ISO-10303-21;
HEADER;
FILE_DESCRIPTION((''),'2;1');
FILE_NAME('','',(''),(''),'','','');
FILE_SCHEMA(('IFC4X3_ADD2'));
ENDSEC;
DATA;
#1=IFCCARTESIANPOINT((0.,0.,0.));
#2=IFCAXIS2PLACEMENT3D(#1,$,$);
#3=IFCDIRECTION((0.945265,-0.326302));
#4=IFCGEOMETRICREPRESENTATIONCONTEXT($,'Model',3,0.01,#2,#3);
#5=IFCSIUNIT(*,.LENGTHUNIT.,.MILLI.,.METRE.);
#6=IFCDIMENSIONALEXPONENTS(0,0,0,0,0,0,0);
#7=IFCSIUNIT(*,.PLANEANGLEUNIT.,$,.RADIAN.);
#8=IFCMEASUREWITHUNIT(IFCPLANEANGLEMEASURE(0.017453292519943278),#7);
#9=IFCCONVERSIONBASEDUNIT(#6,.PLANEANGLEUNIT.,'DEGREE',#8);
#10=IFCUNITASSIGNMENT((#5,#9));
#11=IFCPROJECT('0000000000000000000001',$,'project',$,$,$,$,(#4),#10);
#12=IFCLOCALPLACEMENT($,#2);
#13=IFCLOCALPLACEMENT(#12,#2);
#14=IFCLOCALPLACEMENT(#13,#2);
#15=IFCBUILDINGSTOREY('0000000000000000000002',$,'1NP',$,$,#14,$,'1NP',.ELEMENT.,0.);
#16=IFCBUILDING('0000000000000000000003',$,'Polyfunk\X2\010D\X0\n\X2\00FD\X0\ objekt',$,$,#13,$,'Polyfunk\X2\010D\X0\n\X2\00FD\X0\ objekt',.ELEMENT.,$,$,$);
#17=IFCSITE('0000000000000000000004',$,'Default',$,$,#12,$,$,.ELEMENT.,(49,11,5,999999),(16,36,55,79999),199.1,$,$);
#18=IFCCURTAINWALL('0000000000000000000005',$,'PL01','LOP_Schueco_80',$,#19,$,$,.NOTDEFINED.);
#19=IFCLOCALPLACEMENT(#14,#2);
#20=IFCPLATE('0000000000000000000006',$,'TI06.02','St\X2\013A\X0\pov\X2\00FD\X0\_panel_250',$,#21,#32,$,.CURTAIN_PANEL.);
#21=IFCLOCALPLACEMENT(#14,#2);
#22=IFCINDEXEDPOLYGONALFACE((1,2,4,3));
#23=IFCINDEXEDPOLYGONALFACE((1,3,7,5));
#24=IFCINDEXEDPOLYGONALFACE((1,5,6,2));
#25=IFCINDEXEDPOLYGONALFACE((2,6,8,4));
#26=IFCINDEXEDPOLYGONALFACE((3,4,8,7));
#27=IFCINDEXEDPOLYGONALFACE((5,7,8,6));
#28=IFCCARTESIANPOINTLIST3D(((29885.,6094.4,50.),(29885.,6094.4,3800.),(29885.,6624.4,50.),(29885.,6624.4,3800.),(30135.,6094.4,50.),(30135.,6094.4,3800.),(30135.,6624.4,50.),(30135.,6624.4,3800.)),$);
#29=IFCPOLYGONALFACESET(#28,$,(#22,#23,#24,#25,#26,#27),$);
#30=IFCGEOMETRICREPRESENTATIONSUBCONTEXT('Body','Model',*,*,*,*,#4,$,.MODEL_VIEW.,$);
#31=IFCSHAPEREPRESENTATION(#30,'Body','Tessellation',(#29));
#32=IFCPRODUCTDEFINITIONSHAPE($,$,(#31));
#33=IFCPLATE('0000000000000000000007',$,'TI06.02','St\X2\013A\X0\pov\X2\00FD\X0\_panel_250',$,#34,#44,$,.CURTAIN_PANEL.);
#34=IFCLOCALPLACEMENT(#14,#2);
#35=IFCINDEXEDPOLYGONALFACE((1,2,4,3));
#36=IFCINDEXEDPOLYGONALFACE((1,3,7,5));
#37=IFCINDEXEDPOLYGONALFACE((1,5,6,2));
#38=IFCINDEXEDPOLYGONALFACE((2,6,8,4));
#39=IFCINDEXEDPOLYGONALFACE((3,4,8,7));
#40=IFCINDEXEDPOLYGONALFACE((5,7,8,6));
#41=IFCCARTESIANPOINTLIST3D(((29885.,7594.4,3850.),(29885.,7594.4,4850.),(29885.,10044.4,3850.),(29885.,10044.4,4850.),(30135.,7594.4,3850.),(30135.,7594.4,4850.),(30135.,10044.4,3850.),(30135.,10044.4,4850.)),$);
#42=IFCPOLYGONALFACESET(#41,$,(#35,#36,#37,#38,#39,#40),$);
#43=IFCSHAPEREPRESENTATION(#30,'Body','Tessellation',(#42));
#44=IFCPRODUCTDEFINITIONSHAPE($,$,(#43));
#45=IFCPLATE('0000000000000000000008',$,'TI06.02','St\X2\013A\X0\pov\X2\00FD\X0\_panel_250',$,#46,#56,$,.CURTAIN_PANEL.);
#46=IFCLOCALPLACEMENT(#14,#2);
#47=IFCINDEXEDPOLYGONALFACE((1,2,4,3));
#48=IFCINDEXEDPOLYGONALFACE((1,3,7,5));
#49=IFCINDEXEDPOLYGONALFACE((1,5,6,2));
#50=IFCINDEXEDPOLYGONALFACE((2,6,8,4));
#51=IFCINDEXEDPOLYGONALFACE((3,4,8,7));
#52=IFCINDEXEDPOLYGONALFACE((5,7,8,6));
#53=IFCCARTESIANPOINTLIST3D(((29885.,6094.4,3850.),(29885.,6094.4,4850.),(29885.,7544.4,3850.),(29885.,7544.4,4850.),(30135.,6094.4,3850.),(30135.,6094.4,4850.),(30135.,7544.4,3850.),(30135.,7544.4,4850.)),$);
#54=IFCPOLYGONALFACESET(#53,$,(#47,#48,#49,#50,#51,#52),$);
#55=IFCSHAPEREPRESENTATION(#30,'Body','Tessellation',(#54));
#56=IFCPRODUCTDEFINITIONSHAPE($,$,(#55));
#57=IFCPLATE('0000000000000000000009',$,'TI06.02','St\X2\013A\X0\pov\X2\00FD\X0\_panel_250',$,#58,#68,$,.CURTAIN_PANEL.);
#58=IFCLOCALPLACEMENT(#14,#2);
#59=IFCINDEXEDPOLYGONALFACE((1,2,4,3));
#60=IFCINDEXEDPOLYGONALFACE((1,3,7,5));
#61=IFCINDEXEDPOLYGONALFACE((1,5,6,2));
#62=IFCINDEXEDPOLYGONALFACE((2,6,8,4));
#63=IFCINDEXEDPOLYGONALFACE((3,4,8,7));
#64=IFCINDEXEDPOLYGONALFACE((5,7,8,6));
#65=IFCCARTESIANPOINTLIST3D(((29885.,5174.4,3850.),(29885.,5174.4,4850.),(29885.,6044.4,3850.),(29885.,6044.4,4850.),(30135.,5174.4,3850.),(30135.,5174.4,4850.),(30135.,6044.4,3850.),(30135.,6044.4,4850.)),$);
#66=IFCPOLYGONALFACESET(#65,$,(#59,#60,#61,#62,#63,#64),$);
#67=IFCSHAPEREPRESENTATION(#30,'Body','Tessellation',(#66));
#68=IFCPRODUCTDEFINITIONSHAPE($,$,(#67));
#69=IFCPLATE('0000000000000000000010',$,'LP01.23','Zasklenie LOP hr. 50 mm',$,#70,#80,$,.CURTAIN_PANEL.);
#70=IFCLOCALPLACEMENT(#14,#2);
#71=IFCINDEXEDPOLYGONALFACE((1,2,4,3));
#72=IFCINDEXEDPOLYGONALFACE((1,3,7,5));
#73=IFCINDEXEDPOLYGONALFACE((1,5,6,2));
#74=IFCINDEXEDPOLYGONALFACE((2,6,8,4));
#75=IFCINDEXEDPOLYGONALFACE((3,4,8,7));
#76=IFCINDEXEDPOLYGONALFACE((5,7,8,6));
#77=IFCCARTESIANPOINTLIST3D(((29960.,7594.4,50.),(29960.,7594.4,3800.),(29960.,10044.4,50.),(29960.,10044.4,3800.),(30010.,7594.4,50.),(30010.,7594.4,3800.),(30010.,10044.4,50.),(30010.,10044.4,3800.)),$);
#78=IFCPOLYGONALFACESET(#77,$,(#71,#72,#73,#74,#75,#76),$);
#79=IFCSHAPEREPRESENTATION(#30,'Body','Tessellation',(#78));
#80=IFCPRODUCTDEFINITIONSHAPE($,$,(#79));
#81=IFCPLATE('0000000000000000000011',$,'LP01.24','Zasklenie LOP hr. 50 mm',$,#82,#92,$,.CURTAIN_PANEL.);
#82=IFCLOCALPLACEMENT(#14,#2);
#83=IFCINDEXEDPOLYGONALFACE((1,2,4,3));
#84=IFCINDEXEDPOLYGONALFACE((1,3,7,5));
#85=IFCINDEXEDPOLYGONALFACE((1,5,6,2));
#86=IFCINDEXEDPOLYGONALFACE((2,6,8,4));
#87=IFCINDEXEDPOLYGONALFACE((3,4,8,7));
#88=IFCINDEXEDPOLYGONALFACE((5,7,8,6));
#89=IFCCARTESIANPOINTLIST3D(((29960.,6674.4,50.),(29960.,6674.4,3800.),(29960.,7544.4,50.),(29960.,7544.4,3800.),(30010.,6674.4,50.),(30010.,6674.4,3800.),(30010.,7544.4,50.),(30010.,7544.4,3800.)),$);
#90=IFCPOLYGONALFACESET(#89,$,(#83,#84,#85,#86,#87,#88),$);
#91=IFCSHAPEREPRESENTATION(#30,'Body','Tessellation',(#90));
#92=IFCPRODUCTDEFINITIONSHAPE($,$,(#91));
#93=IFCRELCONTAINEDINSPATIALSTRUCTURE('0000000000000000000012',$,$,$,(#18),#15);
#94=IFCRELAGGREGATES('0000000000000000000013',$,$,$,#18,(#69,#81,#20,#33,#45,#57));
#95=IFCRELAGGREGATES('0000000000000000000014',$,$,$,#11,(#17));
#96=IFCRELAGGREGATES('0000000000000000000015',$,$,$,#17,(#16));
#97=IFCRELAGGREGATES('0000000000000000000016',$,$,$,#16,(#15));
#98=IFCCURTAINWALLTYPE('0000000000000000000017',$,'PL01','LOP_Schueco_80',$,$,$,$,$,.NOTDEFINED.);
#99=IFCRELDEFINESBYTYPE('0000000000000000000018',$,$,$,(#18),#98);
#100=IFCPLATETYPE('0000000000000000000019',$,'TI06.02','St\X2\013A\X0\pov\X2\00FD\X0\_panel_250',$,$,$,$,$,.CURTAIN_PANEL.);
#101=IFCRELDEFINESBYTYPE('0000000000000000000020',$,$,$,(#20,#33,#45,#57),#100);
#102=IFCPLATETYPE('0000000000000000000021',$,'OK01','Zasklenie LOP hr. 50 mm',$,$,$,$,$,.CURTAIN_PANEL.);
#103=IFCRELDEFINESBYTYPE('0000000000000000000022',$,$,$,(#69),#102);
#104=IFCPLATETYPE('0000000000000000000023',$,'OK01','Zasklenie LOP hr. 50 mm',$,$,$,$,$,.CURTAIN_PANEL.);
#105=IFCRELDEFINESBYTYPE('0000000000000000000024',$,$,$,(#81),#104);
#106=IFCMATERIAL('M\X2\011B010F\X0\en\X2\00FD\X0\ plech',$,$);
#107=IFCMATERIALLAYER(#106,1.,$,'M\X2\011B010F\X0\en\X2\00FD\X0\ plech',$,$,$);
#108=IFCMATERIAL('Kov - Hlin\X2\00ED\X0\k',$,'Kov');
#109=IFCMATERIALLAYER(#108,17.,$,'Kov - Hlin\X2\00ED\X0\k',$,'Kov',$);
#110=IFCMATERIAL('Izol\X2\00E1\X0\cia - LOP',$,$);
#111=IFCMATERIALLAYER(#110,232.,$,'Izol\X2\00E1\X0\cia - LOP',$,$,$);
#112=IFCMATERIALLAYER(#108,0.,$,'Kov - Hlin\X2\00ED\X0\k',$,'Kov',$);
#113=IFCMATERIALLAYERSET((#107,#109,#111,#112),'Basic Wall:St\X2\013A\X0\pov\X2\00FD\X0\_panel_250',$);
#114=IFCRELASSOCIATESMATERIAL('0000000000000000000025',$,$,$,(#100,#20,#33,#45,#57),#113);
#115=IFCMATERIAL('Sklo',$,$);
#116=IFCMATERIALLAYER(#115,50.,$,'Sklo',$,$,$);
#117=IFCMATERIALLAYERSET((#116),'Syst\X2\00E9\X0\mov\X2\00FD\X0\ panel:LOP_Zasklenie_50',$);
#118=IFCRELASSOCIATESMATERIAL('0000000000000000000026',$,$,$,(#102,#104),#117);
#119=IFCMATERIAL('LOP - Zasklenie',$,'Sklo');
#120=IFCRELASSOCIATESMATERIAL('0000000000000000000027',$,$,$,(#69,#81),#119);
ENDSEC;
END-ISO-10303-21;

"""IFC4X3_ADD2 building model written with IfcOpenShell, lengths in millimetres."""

from ifc_helpers import new_model, entity, si_unit, converted_unit, direction, frame, frame_2d, origin, place, context, subcontext, project, spatial, rectangle, extrude, source, transform, mapped, material, layer, layer_set, layer_usage, type_object, type_shapes, element, aggregate, save


model = new_model("IFC4X3_ADD2")

# Units and contexts
model_context = context("Model", 3, precision=0.01, world=origin(), true_north=direction((0.945265, -0.326302)))
body_context = subcontext(model_context, "Body", "Model", "MODEL_VIEW")
ifc_project = project(units=[si_unit("LENGTHUNIT", "METRE", prefix="MILLI"), converted_unit("PLANEANGLEUNIT", "DEGREE", entity("IfcPlaneAngleMeasure", 0.017453292519943278), si_unit("PLANEANGLEUNIT", "RADIAN"), dimensions=[0, 0, 0, 0, 0, 0, 0])], contexts=[model_context])

# Site, building, storey
site_placement = place(None, origin())
site = spatial("IfcSite", under=ifc_project, at=site_placement, Name="Default", CompositionType="ELEMENT", RefLatitude=(49, 11, 5, 999999), RefLongitude=(16, 36, 55, 79999), RefElevation=199.1)
building_placement = place(site_placement, origin())
building = spatial("IfcBuilding", under=site, at=building_placement, Name="Polyfunkčný objekt", LongName="Polyfunkčný objekt", CompositionType="ELEMENT")
storey_placement = place(building_placement, origin())
storey = spatial("IfcBuildingStorey", under=building, at=storey_placement, Name="1NP", LongName="1NP", CompositionType="ELEMENT", Elevation=0.0)

# Curtain wall, plates
curtain_wall_type = type_object("IfcCurtainWallType", Name="PL01", Description="LOP_Schueco_80", PredefinedType="NOTDEFINED")
curtain_wall_placement = place(storey_placement, origin())
curtain_wall = element("IfcCurtainWall", 1, at=curtain_wall_placement, inside=storey, type_object=curtain_wall_type, Name="PL01", Description="LOP_Schueco_80", PredefinedType="NOTDEFINED")
ifc_material_1 = material(Name="Měďený plech")
ifc_layer_1 = layer(ifc_material_1, 1.0, Name="Měďený plech")
ifc_material_2 = material(Name="Kov - Hliník", Category="Kov")
ifc_layer_2 = layer(ifc_material_2, 17.0, Name="Kov - Hliník", Category="Kov")
ifc_material_3 = material(Name="Izolácia - LOP")
ifc_layer_3 = layer(ifc_material_3, 232.0, Name="Izolácia - LOP")
ifc_layer_4 = layer(ifc_material_2, 0.0, Name="Kov - Hliník", Category="Kov")
ifc_layer_set_1 = layer_set([ifc_layer_1, ifc_layer_2, ifc_layer_3, ifc_layer_4], Name="Basic Wall:Stĺpový_panel_250")
ifc_layer_usage_1 = layer_usage(ifc_layer_set_1, "AXIS2", "POSITIVE", -125.0)
plate_type_1 = type_object("IfcPlateType", Name="TI06.02", Description="Stĺpový_panel_250", PredefinedType="CURTAIN_PANEL", material=ifc_layer_set_1)
plate_1_placement = place(storey_placement, frame((30010.0, 6624.4, 50.0), z_axis=(0.0, 0.0, 1.0), x_axis=(0.0, -1.0, 0.0)))
plate_1 = element("IfcPlate", 2, at=plate_1_placement, type_object=plate_type_1, material=ifc_layer_usage_1, Name="TI06.02", Description="Stĺpový_panel_250", PredefinedType="CURTAIN_PANEL", context=body_context, shape_type="SweptSolid", body=[
    extrude(rectangle(XDim=250.0, YDim=530.0, at=frame_2d((0.0, 0.0), x_axis=(1.0, 0.0))), frame((265.0, 0.0, 0.0), z_axis=(0.0, 0.0, 1.0), x_axis=(0.0, 1.0, 0.0)), (0.0, 0.0, 1.0), 3750.0),
])
ifc_layer_usage_2 = layer_usage(ifc_layer_set_1, "AXIS2", "POSITIVE", -125.0)
plate_2_placement = place(storey_placement, frame((30010.0, 10044.4, 3850.0), z_axis=(0.0, 0.0, 1.0), x_axis=(0.0, -1.0, 0.0)))
plate_2 = element("IfcPlate", 3, at=plate_2_placement, type_object=plate_type_1, material=ifc_layer_usage_2, Name="TI06.02", Description="Stĺpový_panel_250", PredefinedType="CURTAIN_PANEL", context=body_context, shape_type="SweptSolid", body=[
    extrude(rectangle(XDim=250.0, YDim=2450.0, at=frame_2d((0.0, 0.0), x_axis=(1.0, 0.0))), frame((1225.0, 0.0, 0.0), z_axis=(0.0, 0.0, 1.0), x_axis=(0.0, 1.0, 0.0)), (0.0, 0.0, 1.0), 1000.0),
])
ifc_layer_usage_3 = layer_usage(ifc_layer_set_1, "AXIS2", "POSITIVE", -125.0)
plate_3_placement = place(storey_placement, frame((30010.0, 7544.4, 3850.0), z_axis=(0.0, 0.0, 1.0), x_axis=(0.0, -1.0, 0.0)))
plate_3 = element("IfcPlate", 4, at=plate_3_placement, type_object=plate_type_1, material=ifc_layer_usage_3, Name="TI06.02", Description="Stĺpový_panel_250", PredefinedType="CURTAIN_PANEL", context=body_context, shape_type="SweptSolid", body=[
    extrude(rectangle(XDim=250.0, YDim=1450.0, at=frame_2d((0.0, 0.0), x_axis=(1.0, 0.0))), frame((725.0, 0.0, 0.0), z_axis=(0.0, 0.0, 1.0), x_axis=(0.0, 1.0, 0.0)), (0.0, 0.0, 1.0), 1000.0),
])
ifc_layer_usage_4 = layer_usage(ifc_layer_set_1, "AXIS2", "POSITIVE", -125.0)
plate_4_placement = place(storey_placement, frame((30010.0, 6044.4, 3850.0), z_axis=(0.0, 0.0, 1.0), x_axis=(0.0, -1.0, 0.0)))
plate_4 = element("IfcPlate", 5, at=plate_4_placement, type_object=plate_type_1, material=ifc_layer_usage_4, Name="TI06.02", Description="Stĺpový_panel_250", PredefinedType="CURTAIN_PANEL", context=body_context, shape_type="SweptSolid", body=[
    extrude(rectangle(XDim=250.0, YDim=870.0, at=frame_2d((0.0, 0.0), x_axis=(1.0, 0.0))), frame((435.0, 0.0, 0.0), z_axis=(0.0, 0.0, 1.0), x_axis=(0.0, 1.0, 0.0)), (0.0, 0.0, 1.0), 1000.0),
])
ifc_material_4 = material(Name="LOP - Zasklenie", Category="Sklo")
ifc_material_5 = material(Name="Sklo")
ifc_layer_5 = layer(ifc_material_5, 50.0, Name="Sklo")
ifc_layer_set_2 = layer_set([ifc_layer_5], Name="Systémový panel:LOP_Zasklenie_50")
plate_type_2 = type_object("IfcPlateType", Name="OK01", Description="Zasklenie LOP hr. 50 mm", PredefinedType="CURTAIN_PANEL", material=ifc_layer_set_2)
shared_shape_1 = source(origin(), body_context, "Body", "SweptSolid", [
    extrude(rectangle(XDim=3750.0, YDim=2450.0, at=frame_2d((-141.7, 0.0), x_axis=(1.0, 0.0))), frame((0.0, -50.0, 2016.7), z_axis=(0.0, 1.0, 0.0), x_axis=(0.0, 0.0, 1.0)), (0.0, 0.0, 1.0), 50.0),
])
type_shapes(plate_type_2, [shared_shape_1])
plate_5_placement = place(curtain_wall_placement, frame((30010.0, 8819.4, 50.0), z_axis=(0.0, 0.0, 1.0), x_axis=(0.0, -1.0, 0.0)))
plate_5 = element("IfcPlate", 6, at=plate_5_placement, type_object=plate_type_2, material=ifc_material_4, Name="LP01.23", Description="Zasklenie LOP hr. 50 mm", PredefinedType="CURTAIN_PANEL", context=body_context, shape_type="MappedRepresentation", body=[
    mapped(shared_shape_1, transform((0.0, 0.0, 0.0), scale=1.0)),
])
plate_type_3 = type_object("IfcPlateType", Name="OK01", Description="Zasklenie LOP hr. 50 mm", PredefinedType="CURTAIN_PANEL", material=ifc_layer_set_2)
shared_shape_2 = source(origin(), body_context, "Body", "SweptSolid", [
    extrude(rectangle(XDim=3750.0, YDim=870.0, at=frame_2d((-141.7, 0.0), x_axis=(1.0, 0.0))), frame((0.0, -50.0, 2016.7), z_axis=(0.0, 1.0, 0.0), x_axis=(0.0, 0.0, 1.0)), (0.0, 0.0, 1.0), 50.0),
])
type_shapes(plate_type_3, [shared_shape_2])
plate_6_placement = place(curtain_wall_placement, frame((30010.0, 7109.4, 50.0), z_axis=(0.0, 0.0, 1.0), x_axis=(0.0, -1.0, 0.0)))
plate_6 = element("IfcPlate", 7, at=plate_6_placement, type_object=plate_type_3, material=ifc_material_4, Name="LP01.24", Description="Zasklenie LOP hr. 50 mm", PredefinedType="CURTAIN_PANEL", context=body_context, shape_type="MappedRepresentation", body=[
    mapped(shared_shape_2, transform((0.0, 0.0, 0.0), scale=1.0)),
])
aggregate(curtain_wall, [plate_5, plate_6, plate_1, plate_2, plate_3, plate_4])

save(model, "model.ifc")
